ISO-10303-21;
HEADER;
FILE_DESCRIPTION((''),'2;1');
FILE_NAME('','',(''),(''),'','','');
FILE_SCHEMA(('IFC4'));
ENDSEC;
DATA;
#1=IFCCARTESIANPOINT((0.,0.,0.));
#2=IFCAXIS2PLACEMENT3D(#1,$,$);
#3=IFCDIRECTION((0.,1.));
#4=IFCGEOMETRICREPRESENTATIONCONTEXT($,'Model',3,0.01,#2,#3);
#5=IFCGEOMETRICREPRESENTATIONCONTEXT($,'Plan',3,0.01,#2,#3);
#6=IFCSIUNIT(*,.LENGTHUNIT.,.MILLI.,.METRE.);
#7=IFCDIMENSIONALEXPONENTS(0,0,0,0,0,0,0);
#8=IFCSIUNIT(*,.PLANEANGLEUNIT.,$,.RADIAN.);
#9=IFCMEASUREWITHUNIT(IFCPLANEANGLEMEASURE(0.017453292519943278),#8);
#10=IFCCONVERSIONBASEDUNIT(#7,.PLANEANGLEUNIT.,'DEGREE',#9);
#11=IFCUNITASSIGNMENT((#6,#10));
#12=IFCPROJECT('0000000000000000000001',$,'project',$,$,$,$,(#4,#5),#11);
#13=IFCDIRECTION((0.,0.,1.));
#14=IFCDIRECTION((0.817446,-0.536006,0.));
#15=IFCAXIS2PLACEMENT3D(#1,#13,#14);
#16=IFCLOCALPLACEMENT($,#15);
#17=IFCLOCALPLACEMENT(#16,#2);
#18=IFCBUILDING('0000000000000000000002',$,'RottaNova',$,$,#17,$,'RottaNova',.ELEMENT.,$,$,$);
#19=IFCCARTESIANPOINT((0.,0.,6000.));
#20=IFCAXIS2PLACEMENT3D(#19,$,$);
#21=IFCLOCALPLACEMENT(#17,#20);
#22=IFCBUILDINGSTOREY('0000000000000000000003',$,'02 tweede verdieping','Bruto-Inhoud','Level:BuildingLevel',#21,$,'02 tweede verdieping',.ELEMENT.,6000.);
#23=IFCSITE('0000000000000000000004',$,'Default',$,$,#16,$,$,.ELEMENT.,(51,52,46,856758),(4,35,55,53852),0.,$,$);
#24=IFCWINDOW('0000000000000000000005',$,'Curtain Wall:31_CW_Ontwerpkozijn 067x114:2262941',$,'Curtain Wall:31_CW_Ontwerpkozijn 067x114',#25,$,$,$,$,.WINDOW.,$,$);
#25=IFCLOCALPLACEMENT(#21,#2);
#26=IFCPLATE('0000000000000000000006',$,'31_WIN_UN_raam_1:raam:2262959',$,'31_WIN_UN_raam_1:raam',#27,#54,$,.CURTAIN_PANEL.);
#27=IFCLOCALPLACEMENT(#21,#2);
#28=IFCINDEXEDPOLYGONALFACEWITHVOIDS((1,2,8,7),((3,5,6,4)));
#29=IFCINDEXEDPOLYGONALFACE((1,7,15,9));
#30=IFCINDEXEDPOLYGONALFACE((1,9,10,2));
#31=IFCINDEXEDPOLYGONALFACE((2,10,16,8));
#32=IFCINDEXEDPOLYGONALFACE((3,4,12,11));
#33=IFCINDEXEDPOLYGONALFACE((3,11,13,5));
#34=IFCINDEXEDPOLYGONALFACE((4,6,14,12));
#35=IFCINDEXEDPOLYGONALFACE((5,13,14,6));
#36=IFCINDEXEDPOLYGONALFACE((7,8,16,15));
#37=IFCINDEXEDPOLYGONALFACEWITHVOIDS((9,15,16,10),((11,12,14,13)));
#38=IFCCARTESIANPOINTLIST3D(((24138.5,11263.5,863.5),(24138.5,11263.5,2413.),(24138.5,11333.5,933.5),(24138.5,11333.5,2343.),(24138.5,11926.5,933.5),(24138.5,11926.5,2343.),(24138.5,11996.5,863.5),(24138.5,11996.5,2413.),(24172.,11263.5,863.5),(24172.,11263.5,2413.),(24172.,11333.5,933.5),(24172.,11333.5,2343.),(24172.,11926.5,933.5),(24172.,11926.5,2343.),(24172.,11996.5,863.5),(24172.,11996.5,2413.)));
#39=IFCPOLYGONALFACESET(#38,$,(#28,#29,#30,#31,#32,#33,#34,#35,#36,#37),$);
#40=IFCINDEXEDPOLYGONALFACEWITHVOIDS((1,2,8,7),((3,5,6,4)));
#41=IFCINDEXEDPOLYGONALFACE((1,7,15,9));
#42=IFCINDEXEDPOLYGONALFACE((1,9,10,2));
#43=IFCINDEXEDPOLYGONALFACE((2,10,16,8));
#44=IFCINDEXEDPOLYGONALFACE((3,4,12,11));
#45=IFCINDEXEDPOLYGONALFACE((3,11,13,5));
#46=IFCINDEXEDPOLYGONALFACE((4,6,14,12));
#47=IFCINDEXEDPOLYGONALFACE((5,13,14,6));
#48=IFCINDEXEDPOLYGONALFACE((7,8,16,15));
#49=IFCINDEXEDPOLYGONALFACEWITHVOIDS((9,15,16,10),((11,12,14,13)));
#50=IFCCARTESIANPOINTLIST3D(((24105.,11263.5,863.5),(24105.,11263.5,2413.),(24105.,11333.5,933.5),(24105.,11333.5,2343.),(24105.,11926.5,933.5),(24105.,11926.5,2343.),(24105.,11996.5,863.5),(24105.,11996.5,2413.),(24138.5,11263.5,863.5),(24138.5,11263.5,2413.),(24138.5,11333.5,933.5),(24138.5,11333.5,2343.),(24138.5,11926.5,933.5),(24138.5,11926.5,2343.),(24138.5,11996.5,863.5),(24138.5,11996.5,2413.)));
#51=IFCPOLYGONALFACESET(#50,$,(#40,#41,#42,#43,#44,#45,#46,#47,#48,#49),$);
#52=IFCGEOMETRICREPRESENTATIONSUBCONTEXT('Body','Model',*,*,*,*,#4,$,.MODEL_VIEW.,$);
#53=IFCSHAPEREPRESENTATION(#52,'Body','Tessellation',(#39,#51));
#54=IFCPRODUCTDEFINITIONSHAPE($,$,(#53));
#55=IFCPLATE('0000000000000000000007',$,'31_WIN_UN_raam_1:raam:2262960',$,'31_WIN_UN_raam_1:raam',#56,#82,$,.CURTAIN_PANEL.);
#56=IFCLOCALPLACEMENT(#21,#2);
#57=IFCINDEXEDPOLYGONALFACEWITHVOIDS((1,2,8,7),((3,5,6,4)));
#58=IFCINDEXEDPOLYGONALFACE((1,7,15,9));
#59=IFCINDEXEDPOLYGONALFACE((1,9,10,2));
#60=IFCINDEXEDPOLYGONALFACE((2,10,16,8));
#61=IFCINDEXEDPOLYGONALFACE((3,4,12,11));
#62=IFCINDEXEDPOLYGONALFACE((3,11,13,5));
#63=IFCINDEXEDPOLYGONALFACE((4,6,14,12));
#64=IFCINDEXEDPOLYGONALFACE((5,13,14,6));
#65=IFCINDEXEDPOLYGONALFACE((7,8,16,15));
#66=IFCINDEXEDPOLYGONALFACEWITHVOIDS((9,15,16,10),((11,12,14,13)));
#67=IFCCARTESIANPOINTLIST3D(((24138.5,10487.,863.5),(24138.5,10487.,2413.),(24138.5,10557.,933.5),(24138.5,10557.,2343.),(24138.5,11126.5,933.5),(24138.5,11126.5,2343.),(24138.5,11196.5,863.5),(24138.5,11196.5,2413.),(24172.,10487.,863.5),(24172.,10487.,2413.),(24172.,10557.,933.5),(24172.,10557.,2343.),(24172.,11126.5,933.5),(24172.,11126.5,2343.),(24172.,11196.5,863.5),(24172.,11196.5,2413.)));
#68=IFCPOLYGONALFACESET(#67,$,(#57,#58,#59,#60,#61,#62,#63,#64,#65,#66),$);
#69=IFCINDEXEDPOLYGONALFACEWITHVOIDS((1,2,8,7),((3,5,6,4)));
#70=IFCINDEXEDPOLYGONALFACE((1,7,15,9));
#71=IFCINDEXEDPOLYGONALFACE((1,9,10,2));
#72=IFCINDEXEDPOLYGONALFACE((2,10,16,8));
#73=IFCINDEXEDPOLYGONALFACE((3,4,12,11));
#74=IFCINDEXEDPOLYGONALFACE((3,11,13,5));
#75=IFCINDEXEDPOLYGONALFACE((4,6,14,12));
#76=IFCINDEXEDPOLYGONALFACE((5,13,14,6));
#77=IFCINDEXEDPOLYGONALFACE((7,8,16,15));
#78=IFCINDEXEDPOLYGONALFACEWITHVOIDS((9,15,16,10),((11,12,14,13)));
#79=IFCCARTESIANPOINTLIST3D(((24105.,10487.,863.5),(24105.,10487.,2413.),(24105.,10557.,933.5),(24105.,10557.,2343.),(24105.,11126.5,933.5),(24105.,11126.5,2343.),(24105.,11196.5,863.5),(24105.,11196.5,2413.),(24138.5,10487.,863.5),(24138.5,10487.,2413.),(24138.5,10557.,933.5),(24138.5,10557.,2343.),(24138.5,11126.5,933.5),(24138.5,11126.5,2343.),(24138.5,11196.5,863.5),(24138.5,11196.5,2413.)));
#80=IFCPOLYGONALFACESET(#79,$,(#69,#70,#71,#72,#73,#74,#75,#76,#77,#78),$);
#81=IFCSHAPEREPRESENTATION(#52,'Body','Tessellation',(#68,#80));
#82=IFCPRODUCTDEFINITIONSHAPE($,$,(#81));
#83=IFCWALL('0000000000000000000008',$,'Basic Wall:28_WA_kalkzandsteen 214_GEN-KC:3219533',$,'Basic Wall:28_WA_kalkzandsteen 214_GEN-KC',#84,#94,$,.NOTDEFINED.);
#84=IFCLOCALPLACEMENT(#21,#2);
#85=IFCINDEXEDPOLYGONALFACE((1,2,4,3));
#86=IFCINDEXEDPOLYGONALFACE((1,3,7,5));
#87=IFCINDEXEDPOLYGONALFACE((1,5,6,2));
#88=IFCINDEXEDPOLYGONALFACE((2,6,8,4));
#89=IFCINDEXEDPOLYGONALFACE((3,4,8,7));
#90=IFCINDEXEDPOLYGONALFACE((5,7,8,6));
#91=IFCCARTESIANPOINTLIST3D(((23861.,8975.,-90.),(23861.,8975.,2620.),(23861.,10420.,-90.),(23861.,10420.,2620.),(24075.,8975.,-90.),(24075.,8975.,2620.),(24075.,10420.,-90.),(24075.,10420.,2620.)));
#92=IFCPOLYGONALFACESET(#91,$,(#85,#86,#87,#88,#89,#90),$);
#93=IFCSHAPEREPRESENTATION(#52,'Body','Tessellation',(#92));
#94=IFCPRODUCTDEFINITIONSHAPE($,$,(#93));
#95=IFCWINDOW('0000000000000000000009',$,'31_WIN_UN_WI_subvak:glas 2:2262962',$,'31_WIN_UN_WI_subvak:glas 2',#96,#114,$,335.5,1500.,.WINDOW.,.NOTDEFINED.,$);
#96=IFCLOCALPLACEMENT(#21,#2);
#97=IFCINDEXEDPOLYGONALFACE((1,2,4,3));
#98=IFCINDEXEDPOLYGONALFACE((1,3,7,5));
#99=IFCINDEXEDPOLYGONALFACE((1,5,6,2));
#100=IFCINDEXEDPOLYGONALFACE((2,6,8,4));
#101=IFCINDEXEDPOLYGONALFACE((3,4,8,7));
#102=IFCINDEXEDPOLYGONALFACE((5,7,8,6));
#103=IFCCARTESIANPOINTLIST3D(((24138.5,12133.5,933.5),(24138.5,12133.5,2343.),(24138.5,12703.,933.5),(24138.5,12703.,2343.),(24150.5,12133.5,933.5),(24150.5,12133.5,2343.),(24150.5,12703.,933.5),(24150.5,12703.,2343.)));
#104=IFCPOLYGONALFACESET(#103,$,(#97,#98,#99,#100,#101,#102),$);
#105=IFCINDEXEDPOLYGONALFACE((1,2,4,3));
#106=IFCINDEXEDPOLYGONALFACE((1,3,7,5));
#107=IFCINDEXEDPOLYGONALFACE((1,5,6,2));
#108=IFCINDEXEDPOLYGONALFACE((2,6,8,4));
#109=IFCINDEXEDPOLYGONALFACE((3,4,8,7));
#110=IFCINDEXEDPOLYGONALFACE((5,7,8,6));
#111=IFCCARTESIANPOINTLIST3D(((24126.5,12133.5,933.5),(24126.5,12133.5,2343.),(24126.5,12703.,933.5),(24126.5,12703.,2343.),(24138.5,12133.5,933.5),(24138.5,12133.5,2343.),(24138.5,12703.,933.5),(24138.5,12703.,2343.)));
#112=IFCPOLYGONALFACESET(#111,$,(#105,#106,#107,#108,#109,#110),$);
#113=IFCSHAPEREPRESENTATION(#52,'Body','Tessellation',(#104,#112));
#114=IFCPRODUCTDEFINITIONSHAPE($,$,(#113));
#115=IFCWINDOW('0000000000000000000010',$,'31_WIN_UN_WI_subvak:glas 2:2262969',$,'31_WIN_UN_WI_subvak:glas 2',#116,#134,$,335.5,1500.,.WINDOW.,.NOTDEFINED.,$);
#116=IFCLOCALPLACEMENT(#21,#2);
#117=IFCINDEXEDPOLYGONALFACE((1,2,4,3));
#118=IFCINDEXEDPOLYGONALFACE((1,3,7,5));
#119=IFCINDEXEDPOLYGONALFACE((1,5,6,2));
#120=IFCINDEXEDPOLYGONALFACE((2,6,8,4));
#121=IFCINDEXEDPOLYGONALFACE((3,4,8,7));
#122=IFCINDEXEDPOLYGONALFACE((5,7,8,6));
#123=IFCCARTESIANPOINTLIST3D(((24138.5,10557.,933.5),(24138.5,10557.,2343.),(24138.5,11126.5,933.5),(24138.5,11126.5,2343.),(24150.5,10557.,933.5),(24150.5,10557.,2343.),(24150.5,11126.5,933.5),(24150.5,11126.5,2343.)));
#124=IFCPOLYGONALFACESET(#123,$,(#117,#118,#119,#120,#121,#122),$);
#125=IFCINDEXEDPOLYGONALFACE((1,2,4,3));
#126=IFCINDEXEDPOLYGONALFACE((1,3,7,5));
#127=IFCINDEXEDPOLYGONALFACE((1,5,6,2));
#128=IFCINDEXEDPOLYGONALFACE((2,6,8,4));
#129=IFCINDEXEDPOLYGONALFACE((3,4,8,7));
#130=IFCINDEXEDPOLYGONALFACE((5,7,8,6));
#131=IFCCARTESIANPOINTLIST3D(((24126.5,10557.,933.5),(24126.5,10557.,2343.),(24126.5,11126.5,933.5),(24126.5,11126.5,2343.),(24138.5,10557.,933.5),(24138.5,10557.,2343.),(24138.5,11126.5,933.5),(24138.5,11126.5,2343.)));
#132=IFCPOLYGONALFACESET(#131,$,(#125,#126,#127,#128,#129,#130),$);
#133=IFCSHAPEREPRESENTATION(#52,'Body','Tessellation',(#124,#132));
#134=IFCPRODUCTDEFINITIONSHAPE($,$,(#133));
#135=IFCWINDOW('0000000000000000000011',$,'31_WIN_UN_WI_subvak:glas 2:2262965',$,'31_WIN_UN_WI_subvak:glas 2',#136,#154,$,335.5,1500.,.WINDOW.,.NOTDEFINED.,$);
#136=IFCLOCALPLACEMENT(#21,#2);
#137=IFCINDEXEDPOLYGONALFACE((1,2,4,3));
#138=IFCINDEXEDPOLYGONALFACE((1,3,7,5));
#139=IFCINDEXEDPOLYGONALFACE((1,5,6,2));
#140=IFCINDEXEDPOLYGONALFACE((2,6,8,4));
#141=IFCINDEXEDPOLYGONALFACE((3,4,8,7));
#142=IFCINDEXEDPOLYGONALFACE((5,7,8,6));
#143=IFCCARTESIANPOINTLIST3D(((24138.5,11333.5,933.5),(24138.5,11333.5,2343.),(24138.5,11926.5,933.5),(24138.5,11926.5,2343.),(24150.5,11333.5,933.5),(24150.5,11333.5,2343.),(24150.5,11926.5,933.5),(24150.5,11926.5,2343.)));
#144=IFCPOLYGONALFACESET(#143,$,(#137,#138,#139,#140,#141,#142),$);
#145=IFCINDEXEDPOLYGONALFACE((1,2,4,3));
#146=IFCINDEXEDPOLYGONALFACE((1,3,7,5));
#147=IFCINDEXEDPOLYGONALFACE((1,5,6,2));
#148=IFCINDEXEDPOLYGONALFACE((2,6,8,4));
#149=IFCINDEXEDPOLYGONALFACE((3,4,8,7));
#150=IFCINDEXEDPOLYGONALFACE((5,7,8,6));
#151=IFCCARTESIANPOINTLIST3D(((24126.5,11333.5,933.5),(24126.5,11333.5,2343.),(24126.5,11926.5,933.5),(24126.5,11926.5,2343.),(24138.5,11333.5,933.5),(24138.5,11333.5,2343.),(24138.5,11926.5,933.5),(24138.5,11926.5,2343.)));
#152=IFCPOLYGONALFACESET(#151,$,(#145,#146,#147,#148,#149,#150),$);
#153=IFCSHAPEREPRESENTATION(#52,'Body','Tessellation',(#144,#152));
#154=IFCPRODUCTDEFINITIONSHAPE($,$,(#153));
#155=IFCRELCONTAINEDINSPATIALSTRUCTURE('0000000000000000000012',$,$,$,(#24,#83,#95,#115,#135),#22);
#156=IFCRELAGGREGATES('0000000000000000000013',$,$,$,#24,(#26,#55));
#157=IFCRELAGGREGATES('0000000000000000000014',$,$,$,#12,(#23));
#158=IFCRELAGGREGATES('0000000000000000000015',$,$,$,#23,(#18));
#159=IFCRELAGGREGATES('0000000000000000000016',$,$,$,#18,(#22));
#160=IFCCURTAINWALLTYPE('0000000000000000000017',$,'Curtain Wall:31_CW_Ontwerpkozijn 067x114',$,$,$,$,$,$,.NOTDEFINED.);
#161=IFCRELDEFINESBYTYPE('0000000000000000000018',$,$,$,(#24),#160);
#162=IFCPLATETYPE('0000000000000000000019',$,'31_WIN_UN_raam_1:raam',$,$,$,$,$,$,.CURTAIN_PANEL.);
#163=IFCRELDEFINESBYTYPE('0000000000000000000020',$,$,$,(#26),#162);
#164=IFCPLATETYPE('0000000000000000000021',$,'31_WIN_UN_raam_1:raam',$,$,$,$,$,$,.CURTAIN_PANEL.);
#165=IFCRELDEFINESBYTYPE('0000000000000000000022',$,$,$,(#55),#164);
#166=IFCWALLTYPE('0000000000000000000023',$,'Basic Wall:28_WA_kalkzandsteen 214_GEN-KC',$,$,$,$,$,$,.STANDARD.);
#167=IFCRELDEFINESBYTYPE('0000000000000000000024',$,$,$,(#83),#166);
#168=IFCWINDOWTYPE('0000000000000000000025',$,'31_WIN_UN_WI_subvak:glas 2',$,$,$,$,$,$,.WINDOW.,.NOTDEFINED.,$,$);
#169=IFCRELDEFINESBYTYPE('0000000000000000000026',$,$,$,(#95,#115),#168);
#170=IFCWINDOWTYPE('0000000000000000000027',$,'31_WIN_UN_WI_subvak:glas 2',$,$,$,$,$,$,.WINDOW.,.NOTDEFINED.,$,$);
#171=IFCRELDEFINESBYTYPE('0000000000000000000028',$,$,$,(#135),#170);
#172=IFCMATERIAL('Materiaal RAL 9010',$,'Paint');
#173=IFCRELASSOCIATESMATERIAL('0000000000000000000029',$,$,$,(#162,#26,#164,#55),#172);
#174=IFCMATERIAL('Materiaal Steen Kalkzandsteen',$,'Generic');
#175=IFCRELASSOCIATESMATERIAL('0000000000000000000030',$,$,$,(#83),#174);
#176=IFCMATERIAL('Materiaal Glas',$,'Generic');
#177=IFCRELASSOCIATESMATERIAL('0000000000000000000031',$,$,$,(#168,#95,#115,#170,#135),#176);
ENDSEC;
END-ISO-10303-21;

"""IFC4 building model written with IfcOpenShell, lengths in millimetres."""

from ifc_helpers import new_model, entity, si_unit, converted_unit, direction, frame, origin, place, context, subcontext, project, spatial, indexed_curve, outline, extrude, source, transform, mapped, material, type_object, type_shapes, element, aggregate, save


model = new_model("IFC4")

# Units and contexts
model_context = context("Model", 3, precision=0.01, world=origin(), true_north=direction((0.0, 1.0)))
plan_context = context("Plan", 3, precision=0.01, world=origin(), true_north=direction((0.0, 1.0)))
body_context = subcontext(model_context, "Body", "Model", "MODEL_VIEW")
ifc_project = project(units=[si_unit("LENGTHUNIT", "METRE", prefix="MILLI"), converted_unit("PLANEANGLEUNIT", "DEGREE", entity("IfcPlaneAngleMeasure", 0.017453292519943278), si_unit("PLANEANGLEUNIT", "RADIAN"), dimensions=[0, 0, 0, 0, 0, 0, 0])], contexts=[model_context, plan_context])

# Site, building, storey
site_placement = place(None, frame((0.0, 0.0, 0.0), z_axis=(0.0, 0.0, 1.0), x_axis=(0.817446, -0.536006, 0.0)))
site = spatial("IfcSite", under=ifc_project, at=site_placement, Name="Default", CompositionType="ELEMENT", RefLatitude=(51, 52, 46, 856758), RefLongitude=(4, 35, 55, 53852), RefElevation=0.0)
building_placement = place(site_placement, origin())
building = spatial("IfcBuilding", under=site, at=building_placement, Name="RottaNova", LongName="RottaNova", CompositionType="ELEMENT")
storey_placement = place(building_placement, frame((0.0, 0.0, 6000.0)))
storey = spatial("IfcBuildingStorey", under=building, at=storey_placement, Name="02 tweede verdieping", Description="Bruto-Inhoud", ObjectType="Level:BuildingLevel", LongName="02 tweede verdieping", CompositionType="ELEMENT", Elevation=6000.0)

# Window
curtain_wall_type = type_object("IfcCurtainWallType", Name="Curtain Wall:31_CW_Ontwerpkozijn 067x114", PredefinedType="NOTDEFINED")
window_1_placement = place(storey_placement, frame((0.0, 0.0, -6000.0)))
window_1 = element("IfcWindow", 1, at=window_1_placement, inside=storey, type_object=curtain_wall_type, Name="Curtain Wall:31_CW_Ontwerpkozijn 067x114:2262941", ObjectType="Curtain Wall:31_CW_Ontwerpkozijn 067x114", PredefinedType="WINDOW")

# Plates
ifc_material_1 = material(Name="Materiaal Glas", Category="Generic")
ifc_material_2 = material(Name="Materiaal RAL 9010", Category="Paint")
plate_type_1 = type_object("IfcPlateType", Name="31_WIN_UN_raam_1:raam", PredefinedType="CURTAIN_PANEL", material=ifc_material_2)
shared_shape_1 = source(origin(), body_context, "Body", "SweptSolid", [
    extrude(outline(indexed_curve([(-366.5, -774.8), (366.5, -774.8), (366.5, 774.8), (-366.5, 774.8), (-366.5, -774.8)], self_intersect=False), holes=[indexed_curve([(-296.5, 704.8), (296.5, 704.8), (296.5, -704.8), (-296.5, -704.8), (-296.5, 704.8)], self_intersect=False)]), frame((0.0, 58.5, 774.8), z_axis=(0.0, 1.0, 0.0), x_axis=(1.0, 0.0, 0.0)), (0.0, 0.0, 1.0), 33.5),
    extrude(outline(indexed_curve([(-366.5, -774.8), (366.5, -774.8), (366.5, 774.8), (-366.5, 774.8), (-366.5, -774.8)], self_intersect=False), holes=[indexed_curve([(-296.5, 704.7), (296.5, 704.7), (296.5, -704.8), (-296.5, -704.8), (-296.5, 704.7)], self_intersect=False)]), frame((0.0, 25.0, 774.8), z_axis=(0.0, 1.0, 0.0), x_axis=(1.0, 0.0, 0.0)), (0.0, 0.0, 1.0), 33.5),
])
type_shapes(plate_type_1, [shared_shape_1])
plate_1_placement = place(window_1_placement, frame((24080.0, 11630.0, 6863.5), z_axis=(0.0, 0.0, 1.0), x_axis=(0.0, -1.0, 0.0)))
plate_1 = element("IfcPlate", 2, at=plate_1_placement, type_object=plate_type_1, material=ifc_material_2, Name="31_WIN_UN_raam_1:raam:2262959", ObjectType="31_WIN_UN_raam_1:raam", PredefinedType="CURTAIN_PANEL", context=body_context, shape_type="MappedRepresentation", body=[
    mapped(shared_shape_1, transform((0.0, 0.0, 0.0), scale=1.0)),
])
plate_type_2 = type_object("IfcPlateType", Name="31_WIN_UN_raam_1:raam", PredefinedType="CURTAIN_PANEL", material=ifc_material_2)
shared_shape_2 = source(origin(), body_context, "Body", "SweptSolid", [
    extrude(outline(indexed_curve([(-354.8, -774.7), (354.8, -774.7), (354.8, 774.7), (-354.8, 774.7), (-354.8, -774.7)], self_intersect=False), holes=[indexed_curve([(-284.8, 704.7), (284.8, 704.7), (284.8, -704.8), (-284.8, -704.8), (-284.8, 704.7)], self_intersect=False)]), frame((0.0, 58.5, 774.8), z_axis=(0.0, 1.0, 0.0), x_axis=(1.0, 0.0, 0.0)), (0.0, 0.0, 1.0), 33.5),
    extrude(outline(indexed_curve([(-354.8, -774.7), (354.8, -774.7), (354.8, 774.7), (-354.8, 774.7), (-354.8, -774.7)], self_intersect=False), holes=[indexed_curve([(-284.8, 704.7), (284.8, 704.7), (284.8, -704.8), (-284.8, -704.8), (-284.8, 704.7)], self_intersect=False)]), frame((0.0, 25.0, 774.8), z_axis=(0.0, 1.0, 0.0), x_axis=(1.0, 0.0, 0.0)), (0.0, 0.0, 1.0), 33.5),
])
type_shapes(plate_type_2, [shared_shape_2])
plate_2_placement = place(window_1_placement, frame((24080.0, 10841.7, 6863.5), z_axis=(0.0, 0.0, 1.0), x_axis=(0.0, -1.0, 0.0)))
plate_2 = element("IfcPlate", 3, at=plate_2_placement, type_object=plate_type_2, material=ifc_material_2, Name="31_WIN_UN_raam_1:raam:2262960", ObjectType="31_WIN_UN_raam_1:raam", PredefinedType="CURTAIN_PANEL", context=body_context, shape_type="MappedRepresentation", body=[
    mapped(shared_shape_2, transform((0.0, 0.0, 0.0), scale=1.0)),
])
aggregate(window_1, [plate_1, plate_2])

# Wall
ifc_material_3 = material(Name="Materiaal Steen Kalkzandsteen", Category="Generic")
wall_type = type_object("IfcWallType", Name="Basic Wall:28_WA_kalkzandsteen 214_GEN-KC", PredefinedType="STANDARD")
wall_placement = place(storey_placement, frame((23968.0, 10420.0, -90.0), z_axis=(0.0, 0.0, 1.0), x_axis=(0.0, -1.0, 0.0)))
element("IfcWall", 4, at=wall_placement, inside=storey, type_object=wall_type, material=ifc_material_3, Name="Basic Wall:28_WA_kalkzandsteen 214_GEN-KC:3219533", ObjectType="Basic Wall:28_WA_kalkzandsteen 214_GEN-KC", PredefinedType="NOTDEFINED", context=body_context, shape_type="SweptSolid", body=[
    extrude(outline(indexed_curve([(1445.0, 107.0), (0.0, 107.0), (0.0, -107.0), (1445.0, -107.0), (1445.0, 107.0)], self_intersect=False)), origin(), (0.0, 0.0, 1.0), 2710.0),
])

# Windows
window_type_1 = type_object("IfcWindowType", Name="31_WIN_UN_WI_subvak:glas 2", PartitioningType="NOTDEFINED", PredefinedType="WINDOW", material=ifc_material_1)
shared_shape_3 = source(origin(), body_context, "Body", "SweptSolid", [
    extrude(outline(indexed_curve([(-6.0, -284.7), (6.0, -284.7), (6.0, 284.7), (-6.0, 284.7), (-6.0, -284.7)], self_intersect=False)), frame((0.0, 6.0, 0.0), z_axis=(0.0, 0.0, 1.0), x_axis=(0.0, -1.0, 0.0)), (0.0, 0.0, 1.0), 1409.5),
    extrude(outline(indexed_curve([(-6.0, -284.8), (6.0, -284.8), (6.0, 284.8), (-6.0, 284.8), (-6.0, -284.8)], self_intersect=False)), frame((0.0, -6.0, 0.0), z_axis=(0.0, 0.0, 1.0), x_axis=(0.0, -1.0, 0.0)), (0.0, 0.0, 1.0), 1409.5),
])
type_shapes(window_type_1, [shared_shape_3])
for number, where, z_axis, x_axis, name in (
    (5, (24138.5, 12418.2, 933.5), (0.0, 0.0, 1.0), (0.0, -1.0, 0.0), "31_WIN_UN_WI_subvak:glas 2:2262962"),
    (6, (24138.5, 10841.7, 933.5), (0.0, 0.0, 1.0), (0.0, -1.0, 0.0), "31_WIN_UN_WI_subvak:glas 2:2262969"),
):
    element("IfcWindow", number, at=place(storey_placement, frame(where, z_axis=z_axis, x_axis=x_axis)), inside=storey, type_object=window_type_1, material=ifc_material_1, Name=name, ObjectType="31_WIN_UN_WI_subvak:glas 2", OverallHeight=335.5, OverallWidth=1500.0, PartitioningType="NOTDEFINED", PredefinedType="WINDOW", context=body_context, shape_type="MappedRepresentation", body=[
        mapped(shared_shape_3, transform((0.0, 0.0, 0.0), scale=1.0)),
    ])
window_type_2 = type_object("IfcWindowType", Name="31_WIN_UN_WI_subvak:glas 2", PartitioningType="NOTDEFINED", PredefinedType="WINDOW", material=ifc_material_1)
shared_shape_4 = source(origin(), body_context, "Body", "SweptSolid", [
    extrude(outline(indexed_curve([(-6.0, -296.5), (6.0, -296.5), (6.0, 296.5), (-6.0, 296.5), (-6.0, -296.5)], self_intersect=False)), frame((0.0, 6.0, 0.0), z_axis=(0.0, 0.0, 1.0), x_axis=(0.0, -1.0, 0.0)), (0.0, 0.0, 1.0), 1409.5),
    extrude(outline(indexed_curve([(-6.0, -296.5), (6.0, -296.5), (6.0, 296.5), (-6.0, 296.5), (-6.0, -296.5)], self_intersect=False)), frame((0.0, -6.0, 0.0), z_axis=(0.0, 0.0, 1.0), x_axis=(0.0, -1.0, 0.0)), (0.0, 0.0, 1.0), 1409.5),
])
type_shapes(window_type_2, [shared_shape_4])
window_2_placement = place(storey_placement, frame((24138.5, 11630.0, 933.5), z_axis=(0.0, 0.0, 1.0), x_axis=(0.0, -1.0, 0.0)))
element("IfcWindow", 7, at=window_2_placement, inside=storey, type_object=window_type_2, material=ifc_material_1, Name="31_WIN_UN_WI_subvak:glas 2:2262965", ObjectType="31_WIN_UN_WI_subvak:glas 2", OverallHeight=335.5, OverallWidth=1500.0, PartitioningType="NOTDEFINED", PredefinedType="WINDOW", context=body_context, shape_type="MappedRepresentation", body=[
    mapped(shared_shape_4, transform((0.0, 0.0, 0.0), scale=1.0)),
])

save(model, "model.ifc")
